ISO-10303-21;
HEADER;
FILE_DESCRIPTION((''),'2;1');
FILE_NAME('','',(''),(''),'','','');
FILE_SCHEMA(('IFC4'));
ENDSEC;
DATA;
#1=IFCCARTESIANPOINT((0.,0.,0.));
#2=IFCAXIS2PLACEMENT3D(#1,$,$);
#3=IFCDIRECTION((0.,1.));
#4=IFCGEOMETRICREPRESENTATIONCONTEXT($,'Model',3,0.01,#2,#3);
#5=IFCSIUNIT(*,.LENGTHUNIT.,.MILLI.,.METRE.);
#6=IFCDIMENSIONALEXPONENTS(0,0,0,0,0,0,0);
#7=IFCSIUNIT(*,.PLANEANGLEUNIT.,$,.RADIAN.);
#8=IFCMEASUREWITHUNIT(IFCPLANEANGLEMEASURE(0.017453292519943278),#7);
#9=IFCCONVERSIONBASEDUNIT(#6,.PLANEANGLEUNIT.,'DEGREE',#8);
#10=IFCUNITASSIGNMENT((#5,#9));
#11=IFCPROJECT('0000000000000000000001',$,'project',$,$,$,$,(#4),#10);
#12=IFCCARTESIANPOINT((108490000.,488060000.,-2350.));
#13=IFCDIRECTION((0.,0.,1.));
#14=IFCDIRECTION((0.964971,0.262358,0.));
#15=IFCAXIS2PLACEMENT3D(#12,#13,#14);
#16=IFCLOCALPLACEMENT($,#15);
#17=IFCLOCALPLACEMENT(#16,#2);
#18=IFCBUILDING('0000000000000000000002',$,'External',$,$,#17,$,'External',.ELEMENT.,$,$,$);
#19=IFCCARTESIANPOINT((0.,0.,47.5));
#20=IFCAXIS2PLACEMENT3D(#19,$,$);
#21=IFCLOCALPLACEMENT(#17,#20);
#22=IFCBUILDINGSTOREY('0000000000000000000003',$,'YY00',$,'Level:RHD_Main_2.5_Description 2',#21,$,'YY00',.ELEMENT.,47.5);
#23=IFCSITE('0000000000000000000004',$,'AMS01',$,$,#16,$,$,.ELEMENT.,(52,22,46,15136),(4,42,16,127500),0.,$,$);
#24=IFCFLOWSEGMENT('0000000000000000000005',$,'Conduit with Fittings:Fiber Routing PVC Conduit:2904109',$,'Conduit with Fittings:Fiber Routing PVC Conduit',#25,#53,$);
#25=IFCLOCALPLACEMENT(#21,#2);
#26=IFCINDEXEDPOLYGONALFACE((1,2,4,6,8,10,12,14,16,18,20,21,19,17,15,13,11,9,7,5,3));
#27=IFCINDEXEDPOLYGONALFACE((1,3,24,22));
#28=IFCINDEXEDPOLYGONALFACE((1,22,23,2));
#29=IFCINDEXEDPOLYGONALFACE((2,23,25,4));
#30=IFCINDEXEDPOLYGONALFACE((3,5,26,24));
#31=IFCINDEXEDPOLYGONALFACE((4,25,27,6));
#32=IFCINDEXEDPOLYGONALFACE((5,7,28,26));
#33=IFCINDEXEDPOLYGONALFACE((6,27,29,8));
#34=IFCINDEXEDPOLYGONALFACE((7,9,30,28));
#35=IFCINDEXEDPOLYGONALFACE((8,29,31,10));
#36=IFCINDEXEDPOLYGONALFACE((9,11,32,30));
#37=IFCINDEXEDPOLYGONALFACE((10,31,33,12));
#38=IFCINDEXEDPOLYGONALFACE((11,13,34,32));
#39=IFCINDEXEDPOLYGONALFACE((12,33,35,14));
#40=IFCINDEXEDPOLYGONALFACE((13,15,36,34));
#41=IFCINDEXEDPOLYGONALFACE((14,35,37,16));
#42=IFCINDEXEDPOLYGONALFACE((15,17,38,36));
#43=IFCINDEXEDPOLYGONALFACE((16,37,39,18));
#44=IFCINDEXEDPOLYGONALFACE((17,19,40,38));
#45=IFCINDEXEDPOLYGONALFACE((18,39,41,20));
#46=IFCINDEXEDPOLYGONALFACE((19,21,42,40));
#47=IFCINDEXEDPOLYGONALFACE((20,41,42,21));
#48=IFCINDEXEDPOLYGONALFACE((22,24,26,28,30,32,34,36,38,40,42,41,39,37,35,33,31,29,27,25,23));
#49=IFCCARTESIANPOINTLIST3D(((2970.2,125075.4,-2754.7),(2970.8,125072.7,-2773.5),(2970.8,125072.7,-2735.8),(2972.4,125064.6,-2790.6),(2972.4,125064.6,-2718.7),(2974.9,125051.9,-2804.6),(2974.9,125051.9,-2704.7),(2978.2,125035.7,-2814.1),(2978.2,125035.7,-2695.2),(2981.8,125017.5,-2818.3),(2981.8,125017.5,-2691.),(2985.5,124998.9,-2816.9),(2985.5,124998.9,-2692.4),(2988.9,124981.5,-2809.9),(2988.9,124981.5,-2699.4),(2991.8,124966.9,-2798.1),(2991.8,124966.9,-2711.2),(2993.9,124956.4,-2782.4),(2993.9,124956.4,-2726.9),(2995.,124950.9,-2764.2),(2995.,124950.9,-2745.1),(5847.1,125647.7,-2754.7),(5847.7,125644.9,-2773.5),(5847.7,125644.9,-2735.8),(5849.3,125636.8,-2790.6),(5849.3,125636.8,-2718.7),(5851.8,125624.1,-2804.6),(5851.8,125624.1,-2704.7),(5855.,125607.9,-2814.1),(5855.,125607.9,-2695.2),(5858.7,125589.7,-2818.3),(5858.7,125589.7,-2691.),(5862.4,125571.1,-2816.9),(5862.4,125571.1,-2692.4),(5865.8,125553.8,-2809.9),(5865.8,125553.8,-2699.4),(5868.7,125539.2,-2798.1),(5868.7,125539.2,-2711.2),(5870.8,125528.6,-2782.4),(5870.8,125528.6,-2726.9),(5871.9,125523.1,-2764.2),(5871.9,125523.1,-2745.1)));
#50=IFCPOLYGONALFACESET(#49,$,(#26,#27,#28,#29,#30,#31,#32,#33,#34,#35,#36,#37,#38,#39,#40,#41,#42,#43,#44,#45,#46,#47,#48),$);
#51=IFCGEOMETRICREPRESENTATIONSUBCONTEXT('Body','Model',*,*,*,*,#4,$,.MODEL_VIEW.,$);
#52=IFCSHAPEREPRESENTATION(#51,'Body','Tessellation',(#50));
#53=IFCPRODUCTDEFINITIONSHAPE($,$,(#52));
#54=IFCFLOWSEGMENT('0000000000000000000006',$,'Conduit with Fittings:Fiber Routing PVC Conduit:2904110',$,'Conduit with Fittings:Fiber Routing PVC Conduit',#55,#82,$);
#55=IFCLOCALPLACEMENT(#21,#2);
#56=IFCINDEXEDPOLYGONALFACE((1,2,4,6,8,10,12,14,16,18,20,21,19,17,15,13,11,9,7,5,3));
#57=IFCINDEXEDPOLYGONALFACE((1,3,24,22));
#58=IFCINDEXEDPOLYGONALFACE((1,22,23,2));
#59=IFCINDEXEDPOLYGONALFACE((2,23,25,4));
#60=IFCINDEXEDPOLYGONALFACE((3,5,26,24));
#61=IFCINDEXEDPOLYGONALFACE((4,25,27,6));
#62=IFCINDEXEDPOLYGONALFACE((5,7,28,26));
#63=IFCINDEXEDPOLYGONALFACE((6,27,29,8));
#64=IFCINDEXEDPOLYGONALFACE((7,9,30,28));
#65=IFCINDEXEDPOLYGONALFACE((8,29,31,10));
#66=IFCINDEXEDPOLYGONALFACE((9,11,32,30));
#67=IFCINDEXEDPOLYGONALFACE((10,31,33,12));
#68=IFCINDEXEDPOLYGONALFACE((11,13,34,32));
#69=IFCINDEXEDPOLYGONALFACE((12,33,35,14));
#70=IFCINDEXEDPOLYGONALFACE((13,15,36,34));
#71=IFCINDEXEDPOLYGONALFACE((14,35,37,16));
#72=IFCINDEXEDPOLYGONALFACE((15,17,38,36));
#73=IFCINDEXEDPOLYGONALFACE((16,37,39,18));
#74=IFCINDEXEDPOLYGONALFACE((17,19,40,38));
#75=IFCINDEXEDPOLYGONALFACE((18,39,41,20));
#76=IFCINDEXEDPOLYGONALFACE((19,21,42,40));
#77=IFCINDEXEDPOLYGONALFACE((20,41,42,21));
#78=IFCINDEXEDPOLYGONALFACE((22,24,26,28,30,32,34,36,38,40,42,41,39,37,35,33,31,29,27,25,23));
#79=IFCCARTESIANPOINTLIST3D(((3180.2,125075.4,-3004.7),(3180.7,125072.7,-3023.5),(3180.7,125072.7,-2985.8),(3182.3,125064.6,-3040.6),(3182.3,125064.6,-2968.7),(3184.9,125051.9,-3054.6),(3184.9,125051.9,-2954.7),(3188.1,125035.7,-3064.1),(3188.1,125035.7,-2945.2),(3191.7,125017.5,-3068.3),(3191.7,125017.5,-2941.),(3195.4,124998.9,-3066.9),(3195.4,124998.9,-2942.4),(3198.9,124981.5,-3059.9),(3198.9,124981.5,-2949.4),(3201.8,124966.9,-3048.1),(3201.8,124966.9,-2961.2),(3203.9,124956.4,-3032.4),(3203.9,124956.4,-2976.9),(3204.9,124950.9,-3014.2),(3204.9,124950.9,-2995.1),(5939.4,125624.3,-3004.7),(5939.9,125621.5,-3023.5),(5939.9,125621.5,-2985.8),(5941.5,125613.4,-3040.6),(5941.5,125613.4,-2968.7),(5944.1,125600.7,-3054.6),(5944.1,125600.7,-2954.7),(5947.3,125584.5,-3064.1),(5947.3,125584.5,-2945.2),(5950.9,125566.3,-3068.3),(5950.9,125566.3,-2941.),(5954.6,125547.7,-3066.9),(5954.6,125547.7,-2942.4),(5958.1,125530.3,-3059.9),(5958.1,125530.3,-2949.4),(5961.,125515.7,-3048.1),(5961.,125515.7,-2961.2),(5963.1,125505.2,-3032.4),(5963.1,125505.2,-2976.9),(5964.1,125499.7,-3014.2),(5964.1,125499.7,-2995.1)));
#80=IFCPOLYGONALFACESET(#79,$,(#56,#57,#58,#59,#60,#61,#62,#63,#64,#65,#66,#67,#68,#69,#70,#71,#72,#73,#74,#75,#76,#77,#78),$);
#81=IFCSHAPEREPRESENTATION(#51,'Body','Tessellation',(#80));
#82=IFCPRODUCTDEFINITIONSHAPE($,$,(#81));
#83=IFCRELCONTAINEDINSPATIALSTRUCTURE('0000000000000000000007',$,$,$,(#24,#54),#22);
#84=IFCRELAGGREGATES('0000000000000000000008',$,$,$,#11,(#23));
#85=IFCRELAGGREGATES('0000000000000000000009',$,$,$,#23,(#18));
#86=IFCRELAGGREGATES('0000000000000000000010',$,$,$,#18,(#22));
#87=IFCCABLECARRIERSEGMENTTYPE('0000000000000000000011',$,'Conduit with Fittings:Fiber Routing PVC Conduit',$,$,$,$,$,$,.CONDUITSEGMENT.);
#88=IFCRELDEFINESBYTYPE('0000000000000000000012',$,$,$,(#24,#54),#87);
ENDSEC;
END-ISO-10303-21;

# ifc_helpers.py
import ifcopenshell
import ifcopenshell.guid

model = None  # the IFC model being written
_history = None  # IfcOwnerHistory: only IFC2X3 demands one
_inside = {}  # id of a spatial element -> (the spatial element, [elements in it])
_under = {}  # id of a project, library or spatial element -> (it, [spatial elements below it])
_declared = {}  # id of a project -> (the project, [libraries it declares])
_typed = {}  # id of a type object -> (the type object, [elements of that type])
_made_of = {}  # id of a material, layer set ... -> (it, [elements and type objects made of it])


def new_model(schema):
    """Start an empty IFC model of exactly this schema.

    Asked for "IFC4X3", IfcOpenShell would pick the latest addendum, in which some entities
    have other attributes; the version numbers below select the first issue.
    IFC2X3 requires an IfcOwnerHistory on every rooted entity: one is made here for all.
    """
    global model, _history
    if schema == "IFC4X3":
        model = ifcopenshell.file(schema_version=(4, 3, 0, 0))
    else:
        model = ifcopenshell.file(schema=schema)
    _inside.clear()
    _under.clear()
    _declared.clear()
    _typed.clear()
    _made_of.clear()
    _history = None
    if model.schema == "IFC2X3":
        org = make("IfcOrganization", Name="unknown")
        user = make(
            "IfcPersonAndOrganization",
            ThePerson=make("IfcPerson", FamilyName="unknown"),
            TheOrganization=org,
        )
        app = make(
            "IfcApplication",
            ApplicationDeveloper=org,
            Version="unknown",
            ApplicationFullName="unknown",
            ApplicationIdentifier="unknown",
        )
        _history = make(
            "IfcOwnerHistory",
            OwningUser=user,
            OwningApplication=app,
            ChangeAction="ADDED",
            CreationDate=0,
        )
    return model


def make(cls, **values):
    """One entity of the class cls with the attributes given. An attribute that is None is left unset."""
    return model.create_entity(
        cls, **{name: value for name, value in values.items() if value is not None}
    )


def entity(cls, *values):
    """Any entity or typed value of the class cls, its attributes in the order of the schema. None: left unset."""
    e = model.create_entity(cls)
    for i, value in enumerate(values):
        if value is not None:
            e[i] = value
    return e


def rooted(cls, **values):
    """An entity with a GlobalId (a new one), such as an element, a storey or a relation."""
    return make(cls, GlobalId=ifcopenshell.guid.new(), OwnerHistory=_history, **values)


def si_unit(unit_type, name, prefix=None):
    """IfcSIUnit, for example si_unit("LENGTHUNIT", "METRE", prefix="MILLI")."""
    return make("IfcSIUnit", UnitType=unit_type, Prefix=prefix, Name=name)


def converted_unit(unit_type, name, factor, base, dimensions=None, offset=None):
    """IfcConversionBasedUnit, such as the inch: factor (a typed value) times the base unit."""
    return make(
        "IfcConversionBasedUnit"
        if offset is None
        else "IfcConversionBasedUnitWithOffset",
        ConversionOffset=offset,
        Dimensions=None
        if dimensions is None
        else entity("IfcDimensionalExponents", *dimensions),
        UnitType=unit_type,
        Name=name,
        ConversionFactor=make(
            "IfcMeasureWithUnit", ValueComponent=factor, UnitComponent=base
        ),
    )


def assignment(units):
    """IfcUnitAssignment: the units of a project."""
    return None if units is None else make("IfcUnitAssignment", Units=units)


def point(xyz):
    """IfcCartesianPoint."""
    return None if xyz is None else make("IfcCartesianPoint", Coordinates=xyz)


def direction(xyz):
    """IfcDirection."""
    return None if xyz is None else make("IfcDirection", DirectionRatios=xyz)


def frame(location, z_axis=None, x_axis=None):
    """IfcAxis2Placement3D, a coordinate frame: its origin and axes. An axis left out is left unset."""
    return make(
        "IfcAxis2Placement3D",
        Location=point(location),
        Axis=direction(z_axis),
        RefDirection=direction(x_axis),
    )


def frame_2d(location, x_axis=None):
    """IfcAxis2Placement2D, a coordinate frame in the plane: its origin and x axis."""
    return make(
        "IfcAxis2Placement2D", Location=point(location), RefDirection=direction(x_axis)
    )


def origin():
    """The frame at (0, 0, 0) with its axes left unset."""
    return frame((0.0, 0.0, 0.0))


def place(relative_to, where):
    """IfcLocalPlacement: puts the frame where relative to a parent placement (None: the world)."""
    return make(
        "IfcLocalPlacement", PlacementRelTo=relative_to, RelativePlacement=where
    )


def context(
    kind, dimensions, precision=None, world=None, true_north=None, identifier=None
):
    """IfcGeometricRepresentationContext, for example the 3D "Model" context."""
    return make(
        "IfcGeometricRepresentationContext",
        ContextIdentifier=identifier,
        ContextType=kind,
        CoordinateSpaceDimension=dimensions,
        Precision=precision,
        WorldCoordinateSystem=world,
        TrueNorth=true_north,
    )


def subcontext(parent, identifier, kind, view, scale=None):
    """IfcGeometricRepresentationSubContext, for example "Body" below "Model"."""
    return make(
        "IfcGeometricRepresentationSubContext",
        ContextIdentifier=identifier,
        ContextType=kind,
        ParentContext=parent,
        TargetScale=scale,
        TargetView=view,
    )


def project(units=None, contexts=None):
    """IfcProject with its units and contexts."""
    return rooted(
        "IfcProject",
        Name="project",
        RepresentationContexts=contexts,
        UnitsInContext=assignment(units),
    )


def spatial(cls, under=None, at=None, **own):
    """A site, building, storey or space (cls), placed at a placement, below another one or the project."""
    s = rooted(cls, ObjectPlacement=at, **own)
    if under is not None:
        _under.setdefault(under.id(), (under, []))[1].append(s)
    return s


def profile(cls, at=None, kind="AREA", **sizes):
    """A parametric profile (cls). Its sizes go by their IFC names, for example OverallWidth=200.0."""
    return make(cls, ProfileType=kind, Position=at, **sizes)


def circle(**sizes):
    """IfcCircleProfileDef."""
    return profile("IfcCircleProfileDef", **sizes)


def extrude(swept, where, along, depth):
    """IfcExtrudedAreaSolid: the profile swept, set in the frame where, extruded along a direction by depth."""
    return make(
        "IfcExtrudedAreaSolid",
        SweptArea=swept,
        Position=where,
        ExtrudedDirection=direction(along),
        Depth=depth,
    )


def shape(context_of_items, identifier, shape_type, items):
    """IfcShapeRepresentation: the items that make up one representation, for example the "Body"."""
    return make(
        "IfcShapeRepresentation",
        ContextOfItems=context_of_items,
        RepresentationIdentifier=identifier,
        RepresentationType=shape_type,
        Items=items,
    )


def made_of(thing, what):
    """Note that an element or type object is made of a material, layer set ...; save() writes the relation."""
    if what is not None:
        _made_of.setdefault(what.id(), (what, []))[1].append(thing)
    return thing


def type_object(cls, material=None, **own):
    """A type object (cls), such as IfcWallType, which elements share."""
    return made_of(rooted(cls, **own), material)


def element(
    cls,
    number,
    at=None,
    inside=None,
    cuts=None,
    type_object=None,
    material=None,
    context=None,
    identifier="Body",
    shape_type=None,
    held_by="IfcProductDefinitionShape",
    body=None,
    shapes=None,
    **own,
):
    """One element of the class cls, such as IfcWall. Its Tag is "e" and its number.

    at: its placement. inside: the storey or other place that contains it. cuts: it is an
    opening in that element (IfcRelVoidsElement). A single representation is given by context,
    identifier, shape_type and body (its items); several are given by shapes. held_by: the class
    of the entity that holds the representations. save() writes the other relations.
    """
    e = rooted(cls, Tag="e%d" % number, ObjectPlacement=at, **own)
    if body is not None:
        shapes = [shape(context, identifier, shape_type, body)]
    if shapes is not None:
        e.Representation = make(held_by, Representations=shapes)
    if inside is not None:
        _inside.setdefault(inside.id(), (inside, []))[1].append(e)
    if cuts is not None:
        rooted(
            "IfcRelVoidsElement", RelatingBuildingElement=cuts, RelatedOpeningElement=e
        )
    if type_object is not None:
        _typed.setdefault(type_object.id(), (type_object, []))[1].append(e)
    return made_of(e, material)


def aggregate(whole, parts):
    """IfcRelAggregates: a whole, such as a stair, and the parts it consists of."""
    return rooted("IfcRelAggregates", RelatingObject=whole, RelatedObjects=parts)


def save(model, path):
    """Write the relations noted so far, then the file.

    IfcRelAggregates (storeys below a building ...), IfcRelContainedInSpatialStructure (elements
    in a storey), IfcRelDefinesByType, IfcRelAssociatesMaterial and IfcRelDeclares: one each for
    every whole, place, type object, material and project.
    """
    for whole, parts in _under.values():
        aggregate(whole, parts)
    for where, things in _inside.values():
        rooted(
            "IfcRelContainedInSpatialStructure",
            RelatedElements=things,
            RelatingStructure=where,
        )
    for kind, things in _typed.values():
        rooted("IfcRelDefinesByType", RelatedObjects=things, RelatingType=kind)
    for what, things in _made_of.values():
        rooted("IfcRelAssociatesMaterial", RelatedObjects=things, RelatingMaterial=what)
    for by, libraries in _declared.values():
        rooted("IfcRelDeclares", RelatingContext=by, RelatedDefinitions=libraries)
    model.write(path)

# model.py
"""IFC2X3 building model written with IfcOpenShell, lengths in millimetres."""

from ifc_helpers import new_model, entity, si_unit, converted_unit, direction, frame, frame_2d, origin, place, context, subcontext, project, spatial, circle, extrude, type_object, element, save


model = new_model("IFC2X3")

# Units and contexts
model_context = context("Model", 3, precision=0.01, world=origin(), true_north=direction((0.0, 1.0)))
body_context = subcontext(model_context, "Body", "Model", "MODEL_VIEW")
ifc_project = project(units=[si_unit("LENGTHUNIT", "METRE", prefix="MILLI"), converted_unit("PLANEANGLEUNIT", "DEGREE", entity("IfcPlaneAngleMeasure", 0.017453292519943278), si_unit("PLANEANGLEUNIT", "RADIAN"), dimensions=[0, 0, 0, 0, 0, 0, 0])], contexts=[model_context])

# Site, building, storey
site_placement = place(None, frame((108490000.0, 488060000.0, -2350.0), z_axis=(0.0, 0.0, 1.0), x_axis=(0.964971, 0.262358, 0.0)))
site = spatial("IfcSite", under=ifc_project, at=site_placement, Name="AMS01", CompositionType="ELEMENT", RefLatitude=(52, 22, 46, 15136), RefLongitude=(4, 42, 16, 127500), RefElevation=0.0)
building_placement = place(site_placement, origin())
building = spatial("IfcBuilding", under=site, at=building_placement, Name="External", LongName="External", CompositionType="ELEMENT")
storey_placement = place(building_placement, frame((0.0, 0.0, 47.5)))
storey = spatial("IfcBuildingStorey", under=building, at=storey_placement, Name="YY00", ObjectType="Level:RHD_Main_2.5_Description 2", LongName="YY00", CompositionType="ELEMENT", Elevation=47.5)

# Flow segments
cable_carrier_segment_type = type_object("IfcCableCarrierSegmentType", Name="Conduit with Fittings:Fiber Routing PVC Conduit", PredefinedType="CONDUITSEGMENT")
flow_segment_1_placement = place(storey_placement, origin())
element("IfcFlowSegment", 1, at=flow_segment_1_placement, inside=storey, type_object=cable_carrier_segment_type, Name="Conduit with Fittings:Fiber Routing PVC Conduit:2904109", ObjectType="Conduit with Fittings:Fiber Routing PVC Conduit", context=body_context, shape_type="SweptSolid", body=[
    extrude(circle(Radius=63.9, at=frame_2d((0.0, 0.0), x_axis=(1.0, 0.0))), frame((2982.7, 125012.8, -2754.7), z_axis=(0.980785, 0.19509, 0.0), x_axis=(-0.19509, 0.980785, 0.0)), (0.0, 0.0, 1.0), 2933.3),
])
flow_segment_2_placement = place(storey_placement, origin())
element("IfcFlowSegment", 2, at=flow_segment_2_placement, inside=storey, type_object=cable_carrier_segment_type, Name="Conduit with Fittings:Fiber Routing PVC Conduit:2904110", ObjectType="Conduit with Fittings:Fiber Routing PVC Conduit", context=body_context, shape_type="SweptSolid", body=[
    extrude(circle(Radius=63.9, at=frame_2d((0.0, 0.0), x_axis=(1.0, 0.0))), frame((3192.6, 125012.8, -3004.7), z_axis=(0.980785, 0.19509, 0.0), x_axis=(-0.19509, 0.980785, 0.0)), (0.0, 0.0, 1.0), 2813.3),
])

save(model, "model.ifc")
